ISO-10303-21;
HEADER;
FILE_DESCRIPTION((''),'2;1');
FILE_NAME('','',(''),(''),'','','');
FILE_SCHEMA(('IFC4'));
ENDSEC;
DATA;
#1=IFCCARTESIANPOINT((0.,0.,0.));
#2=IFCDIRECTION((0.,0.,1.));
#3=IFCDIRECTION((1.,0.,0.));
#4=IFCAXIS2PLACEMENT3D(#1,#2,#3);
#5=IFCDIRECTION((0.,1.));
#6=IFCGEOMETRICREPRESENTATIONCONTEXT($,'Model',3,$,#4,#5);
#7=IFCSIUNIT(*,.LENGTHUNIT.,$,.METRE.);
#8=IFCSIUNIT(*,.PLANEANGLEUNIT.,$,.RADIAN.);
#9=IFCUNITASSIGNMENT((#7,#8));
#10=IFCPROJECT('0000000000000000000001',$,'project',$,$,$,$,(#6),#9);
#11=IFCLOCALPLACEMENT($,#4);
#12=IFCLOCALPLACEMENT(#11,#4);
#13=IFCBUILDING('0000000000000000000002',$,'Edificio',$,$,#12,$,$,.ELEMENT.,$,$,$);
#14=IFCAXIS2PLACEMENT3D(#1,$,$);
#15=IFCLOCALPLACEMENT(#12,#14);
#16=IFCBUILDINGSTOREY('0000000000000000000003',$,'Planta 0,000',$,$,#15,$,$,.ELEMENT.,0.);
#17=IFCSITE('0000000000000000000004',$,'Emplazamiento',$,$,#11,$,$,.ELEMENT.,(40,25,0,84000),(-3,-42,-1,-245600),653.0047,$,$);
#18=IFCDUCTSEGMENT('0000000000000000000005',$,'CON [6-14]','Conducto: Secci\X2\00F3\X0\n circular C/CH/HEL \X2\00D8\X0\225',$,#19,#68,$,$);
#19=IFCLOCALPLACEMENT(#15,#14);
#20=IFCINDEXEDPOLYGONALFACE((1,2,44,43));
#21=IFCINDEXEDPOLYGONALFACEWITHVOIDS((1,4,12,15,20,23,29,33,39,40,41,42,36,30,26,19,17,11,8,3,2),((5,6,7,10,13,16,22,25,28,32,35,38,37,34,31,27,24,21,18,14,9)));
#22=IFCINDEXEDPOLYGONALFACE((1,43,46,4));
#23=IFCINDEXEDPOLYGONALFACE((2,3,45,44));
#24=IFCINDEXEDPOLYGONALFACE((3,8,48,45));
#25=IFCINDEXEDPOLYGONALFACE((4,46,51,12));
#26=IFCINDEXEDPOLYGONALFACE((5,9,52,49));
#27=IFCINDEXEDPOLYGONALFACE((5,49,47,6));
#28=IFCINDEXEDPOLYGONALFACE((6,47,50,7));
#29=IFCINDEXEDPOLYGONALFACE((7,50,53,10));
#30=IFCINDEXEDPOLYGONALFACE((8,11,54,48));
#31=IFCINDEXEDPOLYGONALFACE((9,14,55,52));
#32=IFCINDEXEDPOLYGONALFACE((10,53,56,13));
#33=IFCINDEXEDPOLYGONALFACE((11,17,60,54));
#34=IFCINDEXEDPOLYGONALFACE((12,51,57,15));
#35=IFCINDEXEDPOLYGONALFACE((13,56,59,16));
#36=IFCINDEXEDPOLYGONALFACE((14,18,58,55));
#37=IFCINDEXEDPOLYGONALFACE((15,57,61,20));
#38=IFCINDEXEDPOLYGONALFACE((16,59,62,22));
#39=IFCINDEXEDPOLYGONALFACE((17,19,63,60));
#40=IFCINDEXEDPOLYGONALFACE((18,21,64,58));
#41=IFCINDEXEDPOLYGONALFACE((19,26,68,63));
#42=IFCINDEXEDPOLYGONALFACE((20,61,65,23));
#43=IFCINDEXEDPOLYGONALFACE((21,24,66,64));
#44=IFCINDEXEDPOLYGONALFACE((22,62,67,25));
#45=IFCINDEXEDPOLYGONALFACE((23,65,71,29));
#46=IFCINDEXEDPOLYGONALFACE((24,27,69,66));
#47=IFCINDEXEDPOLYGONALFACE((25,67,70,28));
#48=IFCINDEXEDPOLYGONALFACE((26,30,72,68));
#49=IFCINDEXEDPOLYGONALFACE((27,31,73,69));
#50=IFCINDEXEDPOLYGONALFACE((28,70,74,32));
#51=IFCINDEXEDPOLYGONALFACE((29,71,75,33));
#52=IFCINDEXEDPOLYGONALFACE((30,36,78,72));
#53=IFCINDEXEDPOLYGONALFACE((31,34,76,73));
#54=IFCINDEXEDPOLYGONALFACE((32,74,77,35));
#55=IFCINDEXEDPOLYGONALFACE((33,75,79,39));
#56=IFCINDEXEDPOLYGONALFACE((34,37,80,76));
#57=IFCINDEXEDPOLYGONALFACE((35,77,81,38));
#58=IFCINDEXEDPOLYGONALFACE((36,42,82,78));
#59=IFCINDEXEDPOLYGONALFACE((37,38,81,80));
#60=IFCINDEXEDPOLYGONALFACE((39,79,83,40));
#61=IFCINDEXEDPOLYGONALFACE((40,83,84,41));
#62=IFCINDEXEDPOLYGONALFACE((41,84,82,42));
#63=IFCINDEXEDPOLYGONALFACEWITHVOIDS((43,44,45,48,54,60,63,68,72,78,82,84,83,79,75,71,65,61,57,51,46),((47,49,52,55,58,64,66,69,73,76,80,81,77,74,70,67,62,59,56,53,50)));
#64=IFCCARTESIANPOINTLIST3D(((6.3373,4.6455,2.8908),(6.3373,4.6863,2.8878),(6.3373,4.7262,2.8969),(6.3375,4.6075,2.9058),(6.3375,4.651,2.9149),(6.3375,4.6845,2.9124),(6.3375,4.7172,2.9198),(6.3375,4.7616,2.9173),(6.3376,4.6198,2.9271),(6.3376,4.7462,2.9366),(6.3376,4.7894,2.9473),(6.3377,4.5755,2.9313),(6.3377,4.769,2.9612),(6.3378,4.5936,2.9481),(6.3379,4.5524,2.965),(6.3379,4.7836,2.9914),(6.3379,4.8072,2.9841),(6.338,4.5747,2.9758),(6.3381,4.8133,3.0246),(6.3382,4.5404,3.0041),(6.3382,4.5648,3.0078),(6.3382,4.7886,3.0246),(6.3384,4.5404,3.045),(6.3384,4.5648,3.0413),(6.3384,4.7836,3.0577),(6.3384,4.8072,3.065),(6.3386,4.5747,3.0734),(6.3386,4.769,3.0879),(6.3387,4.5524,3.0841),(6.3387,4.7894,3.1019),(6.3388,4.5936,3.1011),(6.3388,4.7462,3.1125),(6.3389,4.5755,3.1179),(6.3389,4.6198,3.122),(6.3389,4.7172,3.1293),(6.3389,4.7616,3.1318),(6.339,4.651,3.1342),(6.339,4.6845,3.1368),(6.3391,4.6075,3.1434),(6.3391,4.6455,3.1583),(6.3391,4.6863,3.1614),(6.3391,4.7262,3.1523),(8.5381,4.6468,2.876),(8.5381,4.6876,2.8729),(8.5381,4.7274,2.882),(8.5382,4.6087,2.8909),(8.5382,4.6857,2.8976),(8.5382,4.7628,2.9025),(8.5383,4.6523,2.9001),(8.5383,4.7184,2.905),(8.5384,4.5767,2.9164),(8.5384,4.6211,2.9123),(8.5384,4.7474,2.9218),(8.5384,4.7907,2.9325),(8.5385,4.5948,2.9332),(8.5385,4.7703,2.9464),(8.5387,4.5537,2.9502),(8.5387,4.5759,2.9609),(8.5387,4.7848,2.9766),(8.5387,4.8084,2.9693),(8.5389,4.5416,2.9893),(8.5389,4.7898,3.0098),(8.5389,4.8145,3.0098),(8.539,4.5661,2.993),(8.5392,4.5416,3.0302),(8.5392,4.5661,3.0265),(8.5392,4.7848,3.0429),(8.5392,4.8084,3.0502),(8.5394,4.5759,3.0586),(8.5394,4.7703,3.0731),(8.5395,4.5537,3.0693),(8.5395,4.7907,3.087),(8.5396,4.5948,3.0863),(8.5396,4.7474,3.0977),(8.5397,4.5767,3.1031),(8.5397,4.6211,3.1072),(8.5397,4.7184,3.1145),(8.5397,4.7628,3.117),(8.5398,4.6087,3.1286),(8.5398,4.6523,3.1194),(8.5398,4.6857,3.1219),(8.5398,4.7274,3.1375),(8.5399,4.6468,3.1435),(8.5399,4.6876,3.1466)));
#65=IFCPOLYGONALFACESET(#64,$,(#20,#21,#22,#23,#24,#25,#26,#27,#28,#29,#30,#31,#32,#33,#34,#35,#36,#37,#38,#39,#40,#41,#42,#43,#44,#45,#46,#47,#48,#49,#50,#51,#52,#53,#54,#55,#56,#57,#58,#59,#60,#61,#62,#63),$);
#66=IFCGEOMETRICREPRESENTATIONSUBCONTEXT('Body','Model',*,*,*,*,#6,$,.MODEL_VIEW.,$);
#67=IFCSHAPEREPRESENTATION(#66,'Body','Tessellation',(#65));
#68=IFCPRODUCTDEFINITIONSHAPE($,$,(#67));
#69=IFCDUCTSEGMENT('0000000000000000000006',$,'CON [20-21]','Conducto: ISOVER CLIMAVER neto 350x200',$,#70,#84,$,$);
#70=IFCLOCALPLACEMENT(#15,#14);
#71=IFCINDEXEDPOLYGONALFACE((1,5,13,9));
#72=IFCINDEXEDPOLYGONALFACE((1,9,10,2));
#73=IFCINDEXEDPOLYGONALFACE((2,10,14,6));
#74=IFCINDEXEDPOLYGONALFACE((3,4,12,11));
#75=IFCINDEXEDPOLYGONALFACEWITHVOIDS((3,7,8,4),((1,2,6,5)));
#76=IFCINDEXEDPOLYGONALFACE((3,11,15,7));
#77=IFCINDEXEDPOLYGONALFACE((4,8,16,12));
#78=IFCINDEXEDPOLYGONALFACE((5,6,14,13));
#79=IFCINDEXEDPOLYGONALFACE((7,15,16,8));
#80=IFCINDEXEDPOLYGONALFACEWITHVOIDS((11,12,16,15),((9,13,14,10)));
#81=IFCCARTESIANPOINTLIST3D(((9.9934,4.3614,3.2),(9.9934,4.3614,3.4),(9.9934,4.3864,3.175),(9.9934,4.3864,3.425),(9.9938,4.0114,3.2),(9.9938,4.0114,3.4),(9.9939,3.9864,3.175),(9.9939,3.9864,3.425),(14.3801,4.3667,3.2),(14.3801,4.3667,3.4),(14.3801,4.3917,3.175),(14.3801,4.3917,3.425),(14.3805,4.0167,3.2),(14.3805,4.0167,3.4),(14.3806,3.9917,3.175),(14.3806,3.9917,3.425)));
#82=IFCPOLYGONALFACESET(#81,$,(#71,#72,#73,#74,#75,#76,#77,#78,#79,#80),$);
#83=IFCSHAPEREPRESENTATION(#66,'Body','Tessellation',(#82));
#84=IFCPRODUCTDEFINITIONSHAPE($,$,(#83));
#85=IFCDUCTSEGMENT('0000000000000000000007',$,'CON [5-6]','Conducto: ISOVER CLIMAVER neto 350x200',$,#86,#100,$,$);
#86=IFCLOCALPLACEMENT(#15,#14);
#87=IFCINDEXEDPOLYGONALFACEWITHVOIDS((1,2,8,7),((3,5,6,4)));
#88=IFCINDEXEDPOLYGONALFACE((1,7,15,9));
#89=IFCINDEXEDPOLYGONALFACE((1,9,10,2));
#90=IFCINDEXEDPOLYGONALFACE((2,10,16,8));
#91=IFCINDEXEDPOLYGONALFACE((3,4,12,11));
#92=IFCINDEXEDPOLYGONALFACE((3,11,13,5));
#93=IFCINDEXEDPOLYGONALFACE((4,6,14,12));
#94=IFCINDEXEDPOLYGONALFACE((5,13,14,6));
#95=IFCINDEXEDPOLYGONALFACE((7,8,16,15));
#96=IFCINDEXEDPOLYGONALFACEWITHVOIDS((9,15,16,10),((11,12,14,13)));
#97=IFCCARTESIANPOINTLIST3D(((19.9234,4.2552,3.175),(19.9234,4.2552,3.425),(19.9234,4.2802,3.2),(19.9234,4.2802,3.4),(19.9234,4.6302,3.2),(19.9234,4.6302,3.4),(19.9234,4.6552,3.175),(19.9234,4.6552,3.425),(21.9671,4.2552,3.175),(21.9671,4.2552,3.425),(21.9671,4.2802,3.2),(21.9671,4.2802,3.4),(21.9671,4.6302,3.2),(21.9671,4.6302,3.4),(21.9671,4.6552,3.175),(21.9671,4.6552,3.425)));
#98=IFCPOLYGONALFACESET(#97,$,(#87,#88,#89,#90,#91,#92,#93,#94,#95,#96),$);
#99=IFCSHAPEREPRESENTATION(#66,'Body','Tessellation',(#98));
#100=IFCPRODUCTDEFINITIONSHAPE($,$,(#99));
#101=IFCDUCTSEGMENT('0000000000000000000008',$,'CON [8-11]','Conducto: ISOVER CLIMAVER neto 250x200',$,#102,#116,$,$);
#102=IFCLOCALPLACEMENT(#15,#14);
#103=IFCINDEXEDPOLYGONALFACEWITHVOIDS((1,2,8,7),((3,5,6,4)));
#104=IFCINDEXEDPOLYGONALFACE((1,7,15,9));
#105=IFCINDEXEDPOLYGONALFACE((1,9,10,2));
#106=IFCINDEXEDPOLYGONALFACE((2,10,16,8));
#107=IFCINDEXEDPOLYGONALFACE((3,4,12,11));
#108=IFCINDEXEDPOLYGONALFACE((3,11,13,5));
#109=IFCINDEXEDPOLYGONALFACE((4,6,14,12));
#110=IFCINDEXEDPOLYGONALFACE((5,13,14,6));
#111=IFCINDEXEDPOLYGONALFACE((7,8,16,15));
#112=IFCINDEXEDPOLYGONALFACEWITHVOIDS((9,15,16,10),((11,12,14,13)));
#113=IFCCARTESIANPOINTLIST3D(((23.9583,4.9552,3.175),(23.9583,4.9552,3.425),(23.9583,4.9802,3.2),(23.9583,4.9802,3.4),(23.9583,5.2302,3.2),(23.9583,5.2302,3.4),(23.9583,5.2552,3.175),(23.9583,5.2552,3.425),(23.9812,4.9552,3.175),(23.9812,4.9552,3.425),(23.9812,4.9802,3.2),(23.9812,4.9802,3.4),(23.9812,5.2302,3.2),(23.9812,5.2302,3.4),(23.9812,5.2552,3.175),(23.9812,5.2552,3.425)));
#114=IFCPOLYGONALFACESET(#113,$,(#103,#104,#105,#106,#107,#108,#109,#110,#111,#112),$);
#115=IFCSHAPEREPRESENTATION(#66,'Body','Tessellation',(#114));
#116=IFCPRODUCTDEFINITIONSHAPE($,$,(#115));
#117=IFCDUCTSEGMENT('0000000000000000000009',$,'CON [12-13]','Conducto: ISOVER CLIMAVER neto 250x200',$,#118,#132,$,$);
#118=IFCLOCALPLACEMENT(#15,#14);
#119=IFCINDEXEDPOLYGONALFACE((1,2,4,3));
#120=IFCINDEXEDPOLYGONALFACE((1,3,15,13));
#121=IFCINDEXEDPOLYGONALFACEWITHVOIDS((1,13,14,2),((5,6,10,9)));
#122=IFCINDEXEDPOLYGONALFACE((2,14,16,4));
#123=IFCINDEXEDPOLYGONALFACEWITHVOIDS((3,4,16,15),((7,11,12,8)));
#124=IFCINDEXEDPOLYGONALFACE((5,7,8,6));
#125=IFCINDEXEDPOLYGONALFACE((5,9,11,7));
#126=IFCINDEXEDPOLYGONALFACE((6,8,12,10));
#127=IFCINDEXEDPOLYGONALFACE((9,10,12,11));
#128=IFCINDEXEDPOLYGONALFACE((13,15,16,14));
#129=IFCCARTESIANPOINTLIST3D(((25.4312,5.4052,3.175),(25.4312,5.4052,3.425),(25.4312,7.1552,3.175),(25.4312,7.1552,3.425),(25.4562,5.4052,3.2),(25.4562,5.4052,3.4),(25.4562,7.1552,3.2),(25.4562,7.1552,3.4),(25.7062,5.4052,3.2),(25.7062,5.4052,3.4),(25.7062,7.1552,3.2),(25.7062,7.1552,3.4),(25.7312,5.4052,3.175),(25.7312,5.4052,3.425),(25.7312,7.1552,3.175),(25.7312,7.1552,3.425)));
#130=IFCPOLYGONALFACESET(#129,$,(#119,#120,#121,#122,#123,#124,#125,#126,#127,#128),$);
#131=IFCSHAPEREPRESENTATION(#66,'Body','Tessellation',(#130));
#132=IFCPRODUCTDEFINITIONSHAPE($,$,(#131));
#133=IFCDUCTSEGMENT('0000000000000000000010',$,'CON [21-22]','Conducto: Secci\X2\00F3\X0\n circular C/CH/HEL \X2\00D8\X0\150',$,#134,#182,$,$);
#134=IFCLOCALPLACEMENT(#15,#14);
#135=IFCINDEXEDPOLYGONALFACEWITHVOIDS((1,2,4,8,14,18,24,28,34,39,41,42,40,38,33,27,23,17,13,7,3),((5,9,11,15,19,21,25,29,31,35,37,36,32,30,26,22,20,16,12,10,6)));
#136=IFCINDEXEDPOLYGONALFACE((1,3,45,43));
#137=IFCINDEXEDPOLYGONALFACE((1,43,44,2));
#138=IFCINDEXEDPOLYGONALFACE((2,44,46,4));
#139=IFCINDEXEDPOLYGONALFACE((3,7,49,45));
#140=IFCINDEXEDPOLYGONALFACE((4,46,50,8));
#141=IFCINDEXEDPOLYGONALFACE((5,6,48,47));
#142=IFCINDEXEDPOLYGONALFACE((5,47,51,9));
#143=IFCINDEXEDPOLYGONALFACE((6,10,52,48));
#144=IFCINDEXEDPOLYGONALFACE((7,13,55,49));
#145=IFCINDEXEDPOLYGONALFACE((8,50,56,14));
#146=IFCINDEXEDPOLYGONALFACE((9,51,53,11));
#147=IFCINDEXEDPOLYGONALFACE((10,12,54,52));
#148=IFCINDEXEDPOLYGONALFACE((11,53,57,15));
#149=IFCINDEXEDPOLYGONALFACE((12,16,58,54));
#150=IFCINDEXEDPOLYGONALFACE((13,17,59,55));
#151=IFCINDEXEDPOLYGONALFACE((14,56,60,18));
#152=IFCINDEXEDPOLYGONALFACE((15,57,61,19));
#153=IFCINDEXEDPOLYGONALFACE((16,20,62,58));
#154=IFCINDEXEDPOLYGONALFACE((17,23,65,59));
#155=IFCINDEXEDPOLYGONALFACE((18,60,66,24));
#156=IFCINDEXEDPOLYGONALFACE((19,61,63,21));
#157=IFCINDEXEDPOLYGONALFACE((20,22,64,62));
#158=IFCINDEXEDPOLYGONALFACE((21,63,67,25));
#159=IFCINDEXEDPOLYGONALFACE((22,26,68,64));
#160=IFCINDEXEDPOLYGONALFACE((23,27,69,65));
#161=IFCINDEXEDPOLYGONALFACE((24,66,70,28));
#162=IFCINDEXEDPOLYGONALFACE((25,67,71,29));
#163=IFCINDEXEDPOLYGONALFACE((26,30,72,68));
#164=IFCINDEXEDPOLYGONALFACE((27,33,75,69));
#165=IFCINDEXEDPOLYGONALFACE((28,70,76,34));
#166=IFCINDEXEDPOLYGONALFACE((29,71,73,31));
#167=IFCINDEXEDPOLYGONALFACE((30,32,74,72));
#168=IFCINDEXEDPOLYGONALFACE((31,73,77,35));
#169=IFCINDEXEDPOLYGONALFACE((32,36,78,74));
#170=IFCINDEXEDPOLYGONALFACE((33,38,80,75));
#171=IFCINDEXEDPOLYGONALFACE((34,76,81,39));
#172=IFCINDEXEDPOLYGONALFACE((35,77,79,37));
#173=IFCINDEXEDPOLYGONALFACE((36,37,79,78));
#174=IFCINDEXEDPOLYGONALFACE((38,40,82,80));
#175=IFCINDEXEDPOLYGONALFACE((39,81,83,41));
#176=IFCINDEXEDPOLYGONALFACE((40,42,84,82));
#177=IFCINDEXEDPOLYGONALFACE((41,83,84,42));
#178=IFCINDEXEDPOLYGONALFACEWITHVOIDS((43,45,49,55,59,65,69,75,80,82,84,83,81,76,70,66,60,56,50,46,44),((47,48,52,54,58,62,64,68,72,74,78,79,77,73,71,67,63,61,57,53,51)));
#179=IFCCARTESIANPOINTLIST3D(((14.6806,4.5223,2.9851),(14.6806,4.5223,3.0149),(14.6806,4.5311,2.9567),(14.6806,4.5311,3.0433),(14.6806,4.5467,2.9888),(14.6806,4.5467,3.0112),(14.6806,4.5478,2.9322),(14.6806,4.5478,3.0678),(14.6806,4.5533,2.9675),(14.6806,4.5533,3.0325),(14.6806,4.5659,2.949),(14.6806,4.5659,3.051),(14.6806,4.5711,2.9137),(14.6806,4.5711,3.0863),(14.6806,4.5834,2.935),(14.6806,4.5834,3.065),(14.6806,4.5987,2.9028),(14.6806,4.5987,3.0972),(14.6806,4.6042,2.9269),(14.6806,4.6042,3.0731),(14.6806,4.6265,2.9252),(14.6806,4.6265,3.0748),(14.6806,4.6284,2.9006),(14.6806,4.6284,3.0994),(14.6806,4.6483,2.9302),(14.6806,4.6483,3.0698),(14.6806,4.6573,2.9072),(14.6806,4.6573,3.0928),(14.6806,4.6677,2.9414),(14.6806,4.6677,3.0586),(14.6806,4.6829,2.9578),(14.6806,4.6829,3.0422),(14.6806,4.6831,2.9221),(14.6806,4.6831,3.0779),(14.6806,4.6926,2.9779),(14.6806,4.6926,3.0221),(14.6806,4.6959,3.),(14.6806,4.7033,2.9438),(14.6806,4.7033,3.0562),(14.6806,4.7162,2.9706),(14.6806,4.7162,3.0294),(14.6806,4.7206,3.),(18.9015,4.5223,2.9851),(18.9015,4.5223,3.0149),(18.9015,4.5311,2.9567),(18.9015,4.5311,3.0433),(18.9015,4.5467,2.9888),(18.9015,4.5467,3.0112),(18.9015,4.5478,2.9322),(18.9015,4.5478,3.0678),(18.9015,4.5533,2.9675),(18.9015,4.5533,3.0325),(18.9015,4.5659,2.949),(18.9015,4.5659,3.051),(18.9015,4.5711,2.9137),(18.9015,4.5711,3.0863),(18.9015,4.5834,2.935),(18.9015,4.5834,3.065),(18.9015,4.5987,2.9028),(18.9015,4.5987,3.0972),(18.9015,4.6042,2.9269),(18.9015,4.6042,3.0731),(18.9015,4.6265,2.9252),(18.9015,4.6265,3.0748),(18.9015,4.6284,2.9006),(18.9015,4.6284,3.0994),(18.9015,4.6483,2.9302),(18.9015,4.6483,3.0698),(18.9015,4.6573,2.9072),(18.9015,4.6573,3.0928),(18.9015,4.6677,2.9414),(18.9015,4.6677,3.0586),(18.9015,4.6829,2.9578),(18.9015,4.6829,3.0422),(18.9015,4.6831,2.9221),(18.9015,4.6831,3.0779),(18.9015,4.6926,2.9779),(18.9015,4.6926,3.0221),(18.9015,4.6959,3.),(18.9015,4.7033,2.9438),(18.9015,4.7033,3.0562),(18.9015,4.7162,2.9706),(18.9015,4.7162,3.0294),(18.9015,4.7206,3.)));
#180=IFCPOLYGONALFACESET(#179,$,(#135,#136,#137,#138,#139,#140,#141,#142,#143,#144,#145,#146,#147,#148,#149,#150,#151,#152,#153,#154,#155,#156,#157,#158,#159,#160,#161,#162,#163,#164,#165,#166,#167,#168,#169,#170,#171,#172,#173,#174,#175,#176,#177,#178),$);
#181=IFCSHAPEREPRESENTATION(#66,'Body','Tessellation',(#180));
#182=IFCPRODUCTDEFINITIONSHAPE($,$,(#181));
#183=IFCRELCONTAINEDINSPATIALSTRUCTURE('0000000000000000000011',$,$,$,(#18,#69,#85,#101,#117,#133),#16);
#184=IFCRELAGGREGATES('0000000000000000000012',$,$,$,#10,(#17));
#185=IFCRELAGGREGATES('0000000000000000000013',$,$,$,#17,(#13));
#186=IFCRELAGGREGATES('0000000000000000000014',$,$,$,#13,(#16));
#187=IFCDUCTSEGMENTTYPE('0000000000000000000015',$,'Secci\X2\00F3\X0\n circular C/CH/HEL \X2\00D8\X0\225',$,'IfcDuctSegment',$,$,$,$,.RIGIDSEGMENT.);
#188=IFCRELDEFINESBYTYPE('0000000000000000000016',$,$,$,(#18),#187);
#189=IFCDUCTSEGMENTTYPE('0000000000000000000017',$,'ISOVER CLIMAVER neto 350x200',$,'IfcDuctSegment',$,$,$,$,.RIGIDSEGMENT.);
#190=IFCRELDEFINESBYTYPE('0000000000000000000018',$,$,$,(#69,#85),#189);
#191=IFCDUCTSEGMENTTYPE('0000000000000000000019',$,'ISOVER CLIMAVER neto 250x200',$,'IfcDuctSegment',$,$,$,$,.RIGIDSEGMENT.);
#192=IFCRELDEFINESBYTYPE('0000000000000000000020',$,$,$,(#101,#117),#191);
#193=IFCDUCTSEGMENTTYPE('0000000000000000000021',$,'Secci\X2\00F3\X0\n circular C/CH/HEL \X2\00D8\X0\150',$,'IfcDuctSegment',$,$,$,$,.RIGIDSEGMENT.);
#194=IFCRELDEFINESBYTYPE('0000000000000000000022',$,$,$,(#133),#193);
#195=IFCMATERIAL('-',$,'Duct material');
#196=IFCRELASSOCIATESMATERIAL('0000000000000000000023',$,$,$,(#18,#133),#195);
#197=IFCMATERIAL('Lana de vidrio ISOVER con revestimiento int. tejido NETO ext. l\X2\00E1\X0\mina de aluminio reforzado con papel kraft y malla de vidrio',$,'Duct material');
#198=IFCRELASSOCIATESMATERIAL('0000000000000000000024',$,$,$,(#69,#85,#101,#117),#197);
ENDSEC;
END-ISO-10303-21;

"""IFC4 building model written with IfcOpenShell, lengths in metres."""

from ifc_helpers import new_model, si_unit, direction, frame, origin, origin_with_axes, origin_2d_with_axis, place, context, subcontext, project, spatial, hollow_rectangle, hollow_circle, extrude, material, type_object, element, save


model = new_model("IFC4")

# Units and contexts
model_context = context("Model", 3, world=origin_with_axes(), true_north=direction((0.0, 1.0)))
body_context = subcontext(model_context, "Body", "Model", "MODEL_VIEW")
ifc_project = project(units=[si_unit("LENGTHUNIT", "METRE"), si_unit("PLANEANGLEUNIT", "RADIAN")], contexts=[model_context])

# Site, building, storey
site_placement = place(None, origin_with_axes())
site = spatial("IfcSite", under=ifc_project, at=site_placement, Name="Emplazamiento", CompositionType="ELEMENT", RefLatitude=(40, 25, 0, 84000), RefLongitude=(-3, -42, -1, -245600), RefElevation=653.0047)
building_placement = place(site_placement, origin_with_axes())
building = spatial("IfcBuilding", under=site, at=building_placement, Name="Edificio", CompositionType="ELEMENT")
storey_placement = place(building_placement, origin())
storey = spatial("IfcBuildingStorey", under=building, at=storey_placement, Name="Planta 0,000", CompositionType="ELEMENT", Elevation=0.0)

# Shared definitions
ifc_material_1 = material(Name="-", Category="Duct material")

# Shared definitions
ifc_material_2 = material(Name="Lana de vidrio ISOVER con revestimiento int. tejido NETO ext. lámina de aluminio reforzado con papel kraft y malla de vidrio", Category="Duct material")

# Duct segments
duct_segment_type_1 = type_object("IfcDuctSegmentType", Name="Sección circular C/CH/HEL Ø225", ApplicableOccurrence="IfcDuctSegment", PredefinedType="RIGIDSEGMENT")
duct_segment_1_placement = place(storey_placement, origin_with_axes())
element("IfcDuctSegment", 1, at=duct_segment_1_placement, inside=storey, type_object=duct_segment_type_1, material=ifc_material_1, Name="CON [6-14]", Description="Conducto: Sección circular C/CH/HEL Ø225", context=body_context, shape_type="SweptSolid", body=[
    extrude(hollow_circle(Radius=0.1372, WallThickness=0.0247, at=origin_2d_with_axis()), frame((6.3382, 4.6761, 3.0246), z_axis=(0.999977, 0.000565, -0.006729), x_axis=(-0.000565, 1.0, 0.0)), (0.0, 0.0, 1.0), 2.2008),
])
duct_segment_type_2 = type_object("IfcDuctSegmentType", Name="ISOVER CLIMAVER neto 350x200", ApplicableOccurrence="IfcDuctSegment", PredefinedType="RIGIDSEGMENT")
duct_segment_2_placement = place(storey_placement, origin_with_axes())
element("IfcDuctSegment", 2, at=duct_segment_2_placement, inside=storey, type_object=duct_segment_type_2, material=ifc_material_2, Name="CON [20-21]", Description="Conducto: ISOVER CLIMAVER neto 350x200", context=body_context, shape_type="SweptSolid", body=[
    extrude(hollow_rectangle(XDim=0.4, YDim=0.25, WallThickness=0.025, at=origin_2d_with_axis()), frame((14.3803, 4.1917, 3.3), z_axis=(-0.999999, -0.001208, 0.0), x_axis=(0.001208, -0.999999, 0.0)), (0.0, 0.0, 1.0), 4.3867),
])
duct_segment_3_placement = place(storey_placement, origin_with_axes())
element("IfcDuctSegment", 3, at=duct_segment_3_placement, inside=storey, type_object=duct_segment_type_2, material=ifc_material_2, Name="CON [5-6]", Description="Conducto: ISOVER CLIMAVER neto 350x200", context=body_context, shape_type="SweptSolid", body=[
    extrude(hollow_rectangle(XDim=0.4, YDim=0.25, WallThickness=0.025, at=origin_2d_with_axis()), frame((19.9234, 4.4552, 3.3), z_axis=(1.0, 0.0, 0.0), x_axis=(0.0, 1.0, 0.0)), (0.0, 0.0, 1.0), 2.0437),
])
duct_segment_type_3 = type_object("IfcDuctSegmentType", Name="ISOVER CLIMAVER neto 250x200", ApplicableOccurrence="IfcDuctSegment", PredefinedType="RIGIDSEGMENT")
duct_segment_4_placement = place(storey_placement, origin_with_axes())
element("IfcDuctSegment", 4, at=duct_segment_4_placement, inside=storey, type_object=duct_segment_type_3, material=ifc_material_2, Name="CON [8-11]", Description="Conducto: ISOVER CLIMAVER neto 250x200", context=body_context, shape_type="SweptSolid", body=[
    extrude(hollow_rectangle(XDim=0.3, YDim=0.25, WallThickness=0.025, at=origin_2d_with_axis()), frame((23.9583, 5.1052, 3.3), z_axis=(1.0, 0.0, 0.0), x_axis=(0.0, 1.0, 0.0)), (0.0, 0.0, 1.0), 0.0228),
])
duct_segment_5_placement = place(storey_placement, origin_with_axes())
element("IfcDuctSegment", 5, at=duct_segment_5_placement, inside=storey, type_object=duct_segment_type_3, material=ifc_material_2, Name="CON [12-13]", Description="Conducto: ISOVER CLIMAVER neto 250x200", context=body_context, shape_type="SweptSolid", body=[
    extrude(hollow_rectangle(XDim=0.3, YDim=0.25, WallThickness=0.025, at=origin_2d_with_axis()), frame((25.5812, 5.4052, 3.3), z_axis=(0.0, 1.0, 0.0), x_axis=(-1.0, 0.0, 0.0)), (0.0, 0.0, 1.0), 1.75),
])
duct_segment_type_4 = type_object("IfcDuctSegmentType", Name="Sección circular C/CH/HEL Ø150", ApplicableOccurrence="IfcDuctSegment", PredefinedType="RIGIDSEGMENT")
duct_segment_6_placement = place(storey_placement, origin_with_axes())
element("IfcDuctSegment", 6, at=duct_segment_6_placement, inside=storey, type_object=duct_segment_type_4, material=ifc_material_1, Name="CON [21-22]", Description="Conducto: Sección circular C/CH/HEL Ø150", context=body_context, shape_type="SweptSolid", body=[
    extrude(hollow_circle(Radius=0.0997, WallThickness=0.0247, at=origin_2d_with_axis()), frame((14.6806, 4.6209, 3.0), z_axis=(1.0, 0.0, 0.0), x_axis=(0.0, 1.0, 0.0)), (0.0, 0.0, 1.0), 4.2209),
])

save(model, "model.ifc")
